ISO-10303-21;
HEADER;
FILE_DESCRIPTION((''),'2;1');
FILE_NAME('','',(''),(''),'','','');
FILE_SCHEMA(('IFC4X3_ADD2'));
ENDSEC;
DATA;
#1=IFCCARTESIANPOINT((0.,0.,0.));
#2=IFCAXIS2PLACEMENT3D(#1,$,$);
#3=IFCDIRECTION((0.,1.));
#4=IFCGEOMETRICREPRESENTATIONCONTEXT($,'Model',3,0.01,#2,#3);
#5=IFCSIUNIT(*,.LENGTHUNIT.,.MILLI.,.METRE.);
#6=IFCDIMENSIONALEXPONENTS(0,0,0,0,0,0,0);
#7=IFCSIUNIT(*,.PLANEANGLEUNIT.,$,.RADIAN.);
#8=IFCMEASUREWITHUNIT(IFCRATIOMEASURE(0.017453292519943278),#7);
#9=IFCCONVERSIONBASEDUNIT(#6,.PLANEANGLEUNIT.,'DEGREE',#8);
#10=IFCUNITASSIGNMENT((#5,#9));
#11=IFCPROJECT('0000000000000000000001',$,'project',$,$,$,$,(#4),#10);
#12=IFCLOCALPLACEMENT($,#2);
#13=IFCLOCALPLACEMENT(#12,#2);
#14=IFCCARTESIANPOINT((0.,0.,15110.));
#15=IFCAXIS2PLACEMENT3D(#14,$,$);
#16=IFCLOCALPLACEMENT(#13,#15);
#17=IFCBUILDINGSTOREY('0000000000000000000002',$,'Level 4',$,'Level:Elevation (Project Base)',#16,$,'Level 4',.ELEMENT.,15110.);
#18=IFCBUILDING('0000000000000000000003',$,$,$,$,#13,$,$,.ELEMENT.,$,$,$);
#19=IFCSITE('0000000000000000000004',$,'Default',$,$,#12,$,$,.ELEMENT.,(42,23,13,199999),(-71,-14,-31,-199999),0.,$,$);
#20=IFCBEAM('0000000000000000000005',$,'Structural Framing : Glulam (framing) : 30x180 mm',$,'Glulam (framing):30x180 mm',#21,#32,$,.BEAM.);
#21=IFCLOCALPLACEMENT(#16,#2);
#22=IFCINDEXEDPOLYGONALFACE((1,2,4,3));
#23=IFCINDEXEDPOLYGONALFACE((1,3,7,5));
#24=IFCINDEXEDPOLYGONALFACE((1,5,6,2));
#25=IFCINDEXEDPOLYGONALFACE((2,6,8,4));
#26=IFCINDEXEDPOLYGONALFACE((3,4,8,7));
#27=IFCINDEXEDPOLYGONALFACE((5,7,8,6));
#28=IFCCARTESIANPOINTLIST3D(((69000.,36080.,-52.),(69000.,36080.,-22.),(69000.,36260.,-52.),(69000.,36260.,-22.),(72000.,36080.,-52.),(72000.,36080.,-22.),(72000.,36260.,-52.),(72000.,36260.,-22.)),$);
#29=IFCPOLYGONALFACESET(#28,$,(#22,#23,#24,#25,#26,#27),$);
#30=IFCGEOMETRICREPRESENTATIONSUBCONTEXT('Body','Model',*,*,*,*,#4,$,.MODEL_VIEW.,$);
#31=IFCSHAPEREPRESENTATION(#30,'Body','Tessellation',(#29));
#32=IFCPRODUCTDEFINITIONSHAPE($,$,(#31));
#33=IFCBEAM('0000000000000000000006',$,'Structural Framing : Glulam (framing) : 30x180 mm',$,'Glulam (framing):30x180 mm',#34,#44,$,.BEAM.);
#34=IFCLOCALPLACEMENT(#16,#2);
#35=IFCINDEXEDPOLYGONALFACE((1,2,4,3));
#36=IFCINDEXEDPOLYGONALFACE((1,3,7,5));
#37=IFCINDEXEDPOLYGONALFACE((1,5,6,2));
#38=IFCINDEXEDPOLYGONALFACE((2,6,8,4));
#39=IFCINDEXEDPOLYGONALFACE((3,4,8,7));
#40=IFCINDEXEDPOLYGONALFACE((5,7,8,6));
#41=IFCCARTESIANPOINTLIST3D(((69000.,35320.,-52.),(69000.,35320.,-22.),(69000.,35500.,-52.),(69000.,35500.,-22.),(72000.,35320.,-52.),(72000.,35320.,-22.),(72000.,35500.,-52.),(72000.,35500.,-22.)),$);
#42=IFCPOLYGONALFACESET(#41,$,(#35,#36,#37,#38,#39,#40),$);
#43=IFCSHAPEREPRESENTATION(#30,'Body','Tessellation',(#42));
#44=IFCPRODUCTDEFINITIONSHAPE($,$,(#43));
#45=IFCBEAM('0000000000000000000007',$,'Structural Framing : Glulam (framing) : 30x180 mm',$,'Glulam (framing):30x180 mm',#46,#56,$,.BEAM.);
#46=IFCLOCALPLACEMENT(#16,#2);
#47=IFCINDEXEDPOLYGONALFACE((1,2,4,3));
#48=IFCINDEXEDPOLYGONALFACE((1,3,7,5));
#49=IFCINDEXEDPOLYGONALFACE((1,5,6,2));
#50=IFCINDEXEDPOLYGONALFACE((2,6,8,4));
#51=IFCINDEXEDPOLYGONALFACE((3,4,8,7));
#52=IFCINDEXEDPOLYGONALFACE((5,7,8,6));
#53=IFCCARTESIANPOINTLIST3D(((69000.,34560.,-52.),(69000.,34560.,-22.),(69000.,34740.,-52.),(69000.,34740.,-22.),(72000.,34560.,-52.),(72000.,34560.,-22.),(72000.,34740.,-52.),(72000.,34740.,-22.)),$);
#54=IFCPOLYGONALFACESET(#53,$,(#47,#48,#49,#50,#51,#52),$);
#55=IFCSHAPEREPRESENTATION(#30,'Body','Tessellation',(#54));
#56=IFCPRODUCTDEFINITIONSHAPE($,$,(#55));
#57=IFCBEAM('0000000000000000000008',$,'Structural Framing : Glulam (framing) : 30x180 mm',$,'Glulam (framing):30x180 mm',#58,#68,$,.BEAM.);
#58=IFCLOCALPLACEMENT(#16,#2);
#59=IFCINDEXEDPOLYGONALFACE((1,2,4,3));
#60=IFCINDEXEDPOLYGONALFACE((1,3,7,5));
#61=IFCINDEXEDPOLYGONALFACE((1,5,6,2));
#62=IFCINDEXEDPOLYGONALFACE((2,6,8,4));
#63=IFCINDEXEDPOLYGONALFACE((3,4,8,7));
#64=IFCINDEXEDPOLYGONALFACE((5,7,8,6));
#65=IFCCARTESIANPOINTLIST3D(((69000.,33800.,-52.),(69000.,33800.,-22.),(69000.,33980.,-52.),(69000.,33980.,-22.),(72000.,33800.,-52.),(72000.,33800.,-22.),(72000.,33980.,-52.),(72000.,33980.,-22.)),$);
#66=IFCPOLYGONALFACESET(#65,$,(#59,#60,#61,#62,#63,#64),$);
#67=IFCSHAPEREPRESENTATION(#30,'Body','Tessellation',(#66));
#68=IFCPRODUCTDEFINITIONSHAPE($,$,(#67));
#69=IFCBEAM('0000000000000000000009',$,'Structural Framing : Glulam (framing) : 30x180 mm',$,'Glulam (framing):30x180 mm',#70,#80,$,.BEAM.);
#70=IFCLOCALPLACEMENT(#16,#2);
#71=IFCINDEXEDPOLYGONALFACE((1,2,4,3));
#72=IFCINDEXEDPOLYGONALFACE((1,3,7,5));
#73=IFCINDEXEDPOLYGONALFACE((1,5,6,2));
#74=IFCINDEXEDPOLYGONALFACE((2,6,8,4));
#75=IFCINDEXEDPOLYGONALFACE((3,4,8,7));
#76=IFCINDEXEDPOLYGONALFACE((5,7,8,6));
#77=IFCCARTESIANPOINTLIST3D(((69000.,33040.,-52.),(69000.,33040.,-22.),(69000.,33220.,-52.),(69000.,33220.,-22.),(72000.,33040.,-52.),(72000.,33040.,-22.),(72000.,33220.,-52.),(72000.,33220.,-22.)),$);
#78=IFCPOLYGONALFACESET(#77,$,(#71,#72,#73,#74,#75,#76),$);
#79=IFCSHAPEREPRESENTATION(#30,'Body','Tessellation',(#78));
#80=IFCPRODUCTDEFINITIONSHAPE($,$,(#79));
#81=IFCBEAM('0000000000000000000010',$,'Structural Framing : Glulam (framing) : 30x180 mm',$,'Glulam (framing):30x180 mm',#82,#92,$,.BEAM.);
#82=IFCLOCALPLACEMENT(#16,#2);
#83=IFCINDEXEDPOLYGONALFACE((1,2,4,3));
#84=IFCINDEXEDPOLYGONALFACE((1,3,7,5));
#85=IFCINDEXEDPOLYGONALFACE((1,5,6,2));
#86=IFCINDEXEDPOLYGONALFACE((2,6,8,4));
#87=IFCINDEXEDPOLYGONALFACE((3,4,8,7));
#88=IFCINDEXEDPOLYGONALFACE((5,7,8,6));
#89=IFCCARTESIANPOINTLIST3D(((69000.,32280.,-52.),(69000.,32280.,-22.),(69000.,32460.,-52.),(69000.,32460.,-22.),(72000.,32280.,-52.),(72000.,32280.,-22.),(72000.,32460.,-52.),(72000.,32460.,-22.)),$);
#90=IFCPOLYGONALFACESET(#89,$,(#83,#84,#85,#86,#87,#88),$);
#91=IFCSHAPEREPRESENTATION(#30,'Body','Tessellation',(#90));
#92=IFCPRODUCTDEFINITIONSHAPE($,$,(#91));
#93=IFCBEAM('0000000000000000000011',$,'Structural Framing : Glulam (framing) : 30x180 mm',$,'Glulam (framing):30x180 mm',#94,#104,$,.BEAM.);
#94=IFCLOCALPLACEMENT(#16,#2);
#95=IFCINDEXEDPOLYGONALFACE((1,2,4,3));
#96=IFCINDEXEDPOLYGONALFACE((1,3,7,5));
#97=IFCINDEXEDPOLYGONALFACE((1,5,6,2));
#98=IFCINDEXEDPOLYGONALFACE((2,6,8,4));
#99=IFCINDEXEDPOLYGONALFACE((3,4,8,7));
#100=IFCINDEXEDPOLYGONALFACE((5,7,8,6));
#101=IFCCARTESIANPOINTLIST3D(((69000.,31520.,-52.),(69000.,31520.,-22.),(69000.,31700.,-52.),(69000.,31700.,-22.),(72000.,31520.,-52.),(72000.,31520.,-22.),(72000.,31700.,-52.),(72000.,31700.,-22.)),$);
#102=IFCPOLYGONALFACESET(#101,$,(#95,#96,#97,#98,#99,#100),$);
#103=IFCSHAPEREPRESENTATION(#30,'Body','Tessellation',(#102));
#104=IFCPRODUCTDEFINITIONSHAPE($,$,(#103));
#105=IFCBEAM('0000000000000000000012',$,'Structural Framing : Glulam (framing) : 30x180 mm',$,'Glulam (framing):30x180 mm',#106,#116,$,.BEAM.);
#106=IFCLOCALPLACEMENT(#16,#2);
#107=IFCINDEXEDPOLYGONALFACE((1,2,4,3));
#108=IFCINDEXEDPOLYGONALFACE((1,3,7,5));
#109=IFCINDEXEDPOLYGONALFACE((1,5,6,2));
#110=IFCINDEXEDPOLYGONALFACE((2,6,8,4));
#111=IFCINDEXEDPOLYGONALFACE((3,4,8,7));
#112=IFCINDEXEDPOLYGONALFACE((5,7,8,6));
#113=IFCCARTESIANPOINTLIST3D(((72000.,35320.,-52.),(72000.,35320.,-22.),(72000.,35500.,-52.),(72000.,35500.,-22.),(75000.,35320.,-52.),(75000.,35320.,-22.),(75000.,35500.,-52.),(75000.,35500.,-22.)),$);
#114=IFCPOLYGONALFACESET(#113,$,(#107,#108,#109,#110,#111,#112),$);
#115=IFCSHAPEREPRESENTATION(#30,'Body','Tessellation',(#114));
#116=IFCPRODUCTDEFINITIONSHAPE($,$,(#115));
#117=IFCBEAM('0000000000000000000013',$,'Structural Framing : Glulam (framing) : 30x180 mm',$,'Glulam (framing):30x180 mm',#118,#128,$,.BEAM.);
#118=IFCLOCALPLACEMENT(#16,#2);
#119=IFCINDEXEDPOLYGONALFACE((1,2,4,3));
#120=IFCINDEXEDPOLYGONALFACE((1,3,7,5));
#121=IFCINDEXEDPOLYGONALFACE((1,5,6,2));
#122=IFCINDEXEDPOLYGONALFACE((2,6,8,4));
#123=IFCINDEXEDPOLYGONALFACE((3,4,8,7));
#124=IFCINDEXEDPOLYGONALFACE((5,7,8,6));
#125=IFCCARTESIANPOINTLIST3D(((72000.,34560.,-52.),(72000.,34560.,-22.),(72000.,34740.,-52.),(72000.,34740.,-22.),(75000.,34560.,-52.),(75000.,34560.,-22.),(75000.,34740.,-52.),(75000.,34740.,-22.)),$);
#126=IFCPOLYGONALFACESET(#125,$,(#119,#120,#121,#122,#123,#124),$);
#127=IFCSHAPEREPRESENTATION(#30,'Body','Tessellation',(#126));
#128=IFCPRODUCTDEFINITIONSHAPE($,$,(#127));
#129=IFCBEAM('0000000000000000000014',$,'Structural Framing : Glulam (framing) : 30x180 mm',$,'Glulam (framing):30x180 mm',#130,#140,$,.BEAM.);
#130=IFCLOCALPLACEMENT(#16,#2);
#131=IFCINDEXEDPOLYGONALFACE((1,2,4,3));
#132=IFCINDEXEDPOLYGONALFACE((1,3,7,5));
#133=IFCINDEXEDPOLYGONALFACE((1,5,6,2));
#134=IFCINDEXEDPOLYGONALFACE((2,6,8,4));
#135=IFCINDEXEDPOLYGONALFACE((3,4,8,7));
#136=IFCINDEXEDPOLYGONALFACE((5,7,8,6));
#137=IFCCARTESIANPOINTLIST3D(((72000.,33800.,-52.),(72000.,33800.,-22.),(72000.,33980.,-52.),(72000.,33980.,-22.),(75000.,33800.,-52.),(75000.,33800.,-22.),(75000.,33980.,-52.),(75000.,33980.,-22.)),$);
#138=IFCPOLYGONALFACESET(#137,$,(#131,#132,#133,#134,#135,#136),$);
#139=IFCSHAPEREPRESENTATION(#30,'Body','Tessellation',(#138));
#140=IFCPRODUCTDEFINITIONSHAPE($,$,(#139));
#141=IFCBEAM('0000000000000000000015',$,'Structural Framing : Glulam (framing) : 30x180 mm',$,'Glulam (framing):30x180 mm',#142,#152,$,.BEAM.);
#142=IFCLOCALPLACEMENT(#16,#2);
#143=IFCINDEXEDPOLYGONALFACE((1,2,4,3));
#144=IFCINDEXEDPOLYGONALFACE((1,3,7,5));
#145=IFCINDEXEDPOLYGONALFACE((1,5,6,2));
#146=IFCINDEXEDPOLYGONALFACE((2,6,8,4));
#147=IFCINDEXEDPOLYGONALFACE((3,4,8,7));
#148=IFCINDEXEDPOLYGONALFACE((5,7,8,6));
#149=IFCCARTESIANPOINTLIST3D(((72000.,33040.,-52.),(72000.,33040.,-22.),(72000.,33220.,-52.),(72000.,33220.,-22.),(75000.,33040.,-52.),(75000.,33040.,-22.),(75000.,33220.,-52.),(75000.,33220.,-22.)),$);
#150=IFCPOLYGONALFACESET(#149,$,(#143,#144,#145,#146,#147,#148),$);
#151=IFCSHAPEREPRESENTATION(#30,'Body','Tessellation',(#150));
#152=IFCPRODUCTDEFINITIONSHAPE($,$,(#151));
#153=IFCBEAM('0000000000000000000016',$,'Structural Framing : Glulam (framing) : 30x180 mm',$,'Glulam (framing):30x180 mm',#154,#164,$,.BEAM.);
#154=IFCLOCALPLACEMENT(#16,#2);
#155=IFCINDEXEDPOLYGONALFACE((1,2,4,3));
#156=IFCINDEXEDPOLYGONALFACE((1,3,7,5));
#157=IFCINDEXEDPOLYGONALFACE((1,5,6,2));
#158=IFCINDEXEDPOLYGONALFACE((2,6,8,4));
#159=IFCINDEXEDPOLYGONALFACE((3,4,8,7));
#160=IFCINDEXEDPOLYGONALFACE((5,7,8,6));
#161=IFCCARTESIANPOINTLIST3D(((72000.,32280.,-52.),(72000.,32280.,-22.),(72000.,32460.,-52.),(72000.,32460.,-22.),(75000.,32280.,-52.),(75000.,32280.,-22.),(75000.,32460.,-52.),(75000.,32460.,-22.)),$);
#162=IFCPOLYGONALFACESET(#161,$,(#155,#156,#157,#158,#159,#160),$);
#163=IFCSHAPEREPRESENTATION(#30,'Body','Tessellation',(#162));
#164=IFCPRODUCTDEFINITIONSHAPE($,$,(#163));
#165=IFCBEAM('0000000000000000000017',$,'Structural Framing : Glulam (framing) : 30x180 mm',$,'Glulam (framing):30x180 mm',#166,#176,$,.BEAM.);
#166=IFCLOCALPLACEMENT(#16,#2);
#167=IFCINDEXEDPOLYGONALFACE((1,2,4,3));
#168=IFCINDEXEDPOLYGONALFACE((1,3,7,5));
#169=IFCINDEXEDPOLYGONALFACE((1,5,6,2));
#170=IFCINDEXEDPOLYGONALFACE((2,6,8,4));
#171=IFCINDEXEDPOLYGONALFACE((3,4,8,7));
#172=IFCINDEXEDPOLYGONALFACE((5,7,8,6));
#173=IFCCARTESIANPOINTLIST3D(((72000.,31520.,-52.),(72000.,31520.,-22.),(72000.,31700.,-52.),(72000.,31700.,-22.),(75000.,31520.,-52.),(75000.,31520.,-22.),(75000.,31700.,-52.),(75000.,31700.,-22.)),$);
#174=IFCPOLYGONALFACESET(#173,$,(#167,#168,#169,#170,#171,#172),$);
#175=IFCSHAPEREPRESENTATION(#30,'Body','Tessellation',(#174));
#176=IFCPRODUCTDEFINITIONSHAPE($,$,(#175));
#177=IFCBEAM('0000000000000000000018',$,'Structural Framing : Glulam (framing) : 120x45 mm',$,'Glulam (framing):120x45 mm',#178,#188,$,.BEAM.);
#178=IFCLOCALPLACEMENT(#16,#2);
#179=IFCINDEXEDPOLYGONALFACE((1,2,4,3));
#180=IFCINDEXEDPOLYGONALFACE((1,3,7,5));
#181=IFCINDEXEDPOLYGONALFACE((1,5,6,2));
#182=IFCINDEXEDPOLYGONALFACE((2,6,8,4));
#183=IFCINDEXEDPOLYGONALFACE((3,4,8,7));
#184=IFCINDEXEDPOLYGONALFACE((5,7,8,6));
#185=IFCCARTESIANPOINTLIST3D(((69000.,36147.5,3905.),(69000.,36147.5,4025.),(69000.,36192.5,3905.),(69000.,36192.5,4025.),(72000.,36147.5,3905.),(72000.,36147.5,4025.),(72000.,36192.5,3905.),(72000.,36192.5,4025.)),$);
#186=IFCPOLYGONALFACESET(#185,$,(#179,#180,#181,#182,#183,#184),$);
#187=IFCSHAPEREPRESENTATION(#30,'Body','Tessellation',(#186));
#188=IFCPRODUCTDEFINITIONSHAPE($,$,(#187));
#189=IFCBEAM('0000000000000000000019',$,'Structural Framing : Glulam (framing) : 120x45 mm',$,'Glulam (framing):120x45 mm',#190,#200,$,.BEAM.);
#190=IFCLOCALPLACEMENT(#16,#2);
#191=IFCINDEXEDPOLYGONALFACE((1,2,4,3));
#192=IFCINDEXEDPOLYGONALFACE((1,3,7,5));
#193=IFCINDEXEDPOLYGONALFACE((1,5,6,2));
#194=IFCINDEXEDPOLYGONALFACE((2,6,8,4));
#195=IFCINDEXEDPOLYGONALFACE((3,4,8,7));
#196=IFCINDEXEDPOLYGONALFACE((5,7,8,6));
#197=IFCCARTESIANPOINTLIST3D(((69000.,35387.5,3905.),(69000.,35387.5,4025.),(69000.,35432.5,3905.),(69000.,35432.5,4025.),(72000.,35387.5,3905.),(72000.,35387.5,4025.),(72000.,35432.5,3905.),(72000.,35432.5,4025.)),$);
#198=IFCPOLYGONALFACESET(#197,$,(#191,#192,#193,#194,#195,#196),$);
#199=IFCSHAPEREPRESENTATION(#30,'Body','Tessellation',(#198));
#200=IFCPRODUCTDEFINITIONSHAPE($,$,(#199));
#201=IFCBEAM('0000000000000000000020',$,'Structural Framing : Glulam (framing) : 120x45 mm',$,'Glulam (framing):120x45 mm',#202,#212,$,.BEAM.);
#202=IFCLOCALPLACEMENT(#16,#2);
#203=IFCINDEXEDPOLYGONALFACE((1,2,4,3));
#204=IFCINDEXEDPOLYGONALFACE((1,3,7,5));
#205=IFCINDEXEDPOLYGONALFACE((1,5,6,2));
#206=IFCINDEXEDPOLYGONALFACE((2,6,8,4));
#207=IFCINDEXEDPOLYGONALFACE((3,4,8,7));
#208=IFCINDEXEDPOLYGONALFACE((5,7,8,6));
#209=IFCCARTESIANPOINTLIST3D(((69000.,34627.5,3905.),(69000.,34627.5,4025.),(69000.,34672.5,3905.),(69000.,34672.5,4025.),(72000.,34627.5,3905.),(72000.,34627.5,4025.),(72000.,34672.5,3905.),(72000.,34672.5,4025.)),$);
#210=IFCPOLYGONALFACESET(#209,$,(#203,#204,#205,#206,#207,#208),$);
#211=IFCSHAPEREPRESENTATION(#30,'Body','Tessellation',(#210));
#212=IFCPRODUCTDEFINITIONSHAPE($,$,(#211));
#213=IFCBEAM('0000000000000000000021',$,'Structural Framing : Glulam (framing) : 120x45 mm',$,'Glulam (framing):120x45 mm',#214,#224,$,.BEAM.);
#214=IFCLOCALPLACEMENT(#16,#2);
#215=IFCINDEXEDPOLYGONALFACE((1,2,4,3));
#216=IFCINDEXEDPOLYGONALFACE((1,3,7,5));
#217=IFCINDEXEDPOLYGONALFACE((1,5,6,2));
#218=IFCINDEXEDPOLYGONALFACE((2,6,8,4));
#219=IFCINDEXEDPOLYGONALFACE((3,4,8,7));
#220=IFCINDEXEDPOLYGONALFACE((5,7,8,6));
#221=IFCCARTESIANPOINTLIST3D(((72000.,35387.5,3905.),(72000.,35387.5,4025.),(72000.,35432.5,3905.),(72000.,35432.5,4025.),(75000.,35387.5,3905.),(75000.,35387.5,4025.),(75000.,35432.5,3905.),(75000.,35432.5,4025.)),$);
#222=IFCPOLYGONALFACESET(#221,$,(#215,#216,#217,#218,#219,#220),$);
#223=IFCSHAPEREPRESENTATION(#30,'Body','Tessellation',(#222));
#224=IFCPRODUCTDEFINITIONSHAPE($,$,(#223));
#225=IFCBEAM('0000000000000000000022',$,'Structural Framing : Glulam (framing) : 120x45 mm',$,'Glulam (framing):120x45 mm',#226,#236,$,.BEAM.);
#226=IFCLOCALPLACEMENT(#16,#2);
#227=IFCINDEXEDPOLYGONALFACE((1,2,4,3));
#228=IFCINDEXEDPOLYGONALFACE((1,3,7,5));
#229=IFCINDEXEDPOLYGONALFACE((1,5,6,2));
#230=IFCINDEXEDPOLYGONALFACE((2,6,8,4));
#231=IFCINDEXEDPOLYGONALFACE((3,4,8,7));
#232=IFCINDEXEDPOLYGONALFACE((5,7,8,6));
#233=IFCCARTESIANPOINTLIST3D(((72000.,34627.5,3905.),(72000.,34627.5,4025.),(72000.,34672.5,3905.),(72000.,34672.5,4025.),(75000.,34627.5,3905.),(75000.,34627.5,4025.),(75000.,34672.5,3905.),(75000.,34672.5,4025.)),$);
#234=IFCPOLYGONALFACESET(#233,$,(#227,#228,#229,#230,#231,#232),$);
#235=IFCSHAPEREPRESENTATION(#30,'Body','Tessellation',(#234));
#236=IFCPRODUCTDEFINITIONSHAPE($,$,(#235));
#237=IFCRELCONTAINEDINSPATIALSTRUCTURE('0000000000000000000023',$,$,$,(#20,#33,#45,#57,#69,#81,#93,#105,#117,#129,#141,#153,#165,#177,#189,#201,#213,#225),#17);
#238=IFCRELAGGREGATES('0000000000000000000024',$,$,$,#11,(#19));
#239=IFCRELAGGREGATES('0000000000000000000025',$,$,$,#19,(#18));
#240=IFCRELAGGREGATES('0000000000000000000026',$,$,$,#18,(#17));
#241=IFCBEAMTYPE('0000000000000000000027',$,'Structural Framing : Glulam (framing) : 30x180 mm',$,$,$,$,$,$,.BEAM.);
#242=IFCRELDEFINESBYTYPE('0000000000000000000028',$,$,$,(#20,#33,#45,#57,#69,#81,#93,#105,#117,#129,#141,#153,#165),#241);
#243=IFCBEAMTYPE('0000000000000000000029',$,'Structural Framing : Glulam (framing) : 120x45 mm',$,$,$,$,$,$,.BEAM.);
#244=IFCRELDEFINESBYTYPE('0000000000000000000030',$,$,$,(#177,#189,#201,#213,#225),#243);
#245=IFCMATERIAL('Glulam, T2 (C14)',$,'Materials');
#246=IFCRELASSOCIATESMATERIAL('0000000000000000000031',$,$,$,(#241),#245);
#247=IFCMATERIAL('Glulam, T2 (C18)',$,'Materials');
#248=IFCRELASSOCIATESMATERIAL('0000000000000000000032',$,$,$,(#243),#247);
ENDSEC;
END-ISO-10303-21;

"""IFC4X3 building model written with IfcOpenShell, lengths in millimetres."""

from ifc_helpers import new_model, entity, si_unit, converted_unit, direction, frame, origin, origin_2d_with_axis, place, context, subcontext, project, spatial, rectangle, extrude, source, transform, mapped, material, material_profile, profile_set, type_object, type_shapes, element, save


model = new_model("IFC4X3")

# Units and contexts
model_context = context("Model", 3, precision=0.01, world=origin(), true_north=direction((0.0, 1.0)))
body_context = subcontext(model_context, "Body", "Model", "MODEL_VIEW")
ifc_project = project(units=[si_unit("LENGTHUNIT", "METRE", prefix="MILLI"), converted_unit("PLANEANGLEUNIT", "DEGREE", entity("IfcRatioMeasure", 0.017453292519943278), si_unit("PLANEANGLEUNIT", "RADIAN"), dimensions=[0, 0, 0, 0, 0, 0, 0])], contexts=[model_context])

# Site, building, storey
site_placement = place(None, origin())
site = spatial("IfcSite", under=ifc_project, at=site_placement, Name="Default", CompositionType="ELEMENT", RefLatitude=(42, 23, 13, 199999), RefLongitude=(-71, -14, -31, -199999), RefElevation=0.0)
building_placement = place(site_placement, origin())
building = spatial("IfcBuilding", under=site, at=building_placement, CompositionType="ELEMENT")
storey_placement = place(building_placement, frame((0.0, 0.0, 15110.0)))
storey = spatial("IfcBuildingStorey", under=building, at=storey_placement, Name="Level 4", ObjectType="Level:Elevation (Project Base)", LongName="Level 4", CompositionType="ELEMENT", Elevation=15110.0)

# Beams
ifc_material_1 = material(Name="Glulam, T2 (C14)", Category="Materials")
ifc_material_profile_1 = material_profile(ifc_material_1, rectangle(XDim=30.0, YDim=180.0, at=origin_2d_with_axis()), Name="30x180 mm")
ifc_profile_set_1 = profile_set([ifc_material_profile_1], Name="30x180 mm")
beam_type_1 = type_object("IfcBeamType", Name="Structural Framing : Glulam (framing) : 30x180 mm", PredefinedType="BEAM", material=ifc_profile_set_1)
shared_shape_1 = source(origin(), body_context, "Body", "SweptSolid", [
    extrude(rectangle(XDim=30.0, YDim=180.0, at=origin_2d_with_axis()), frame((500.0, 0.0, 0.0), z_axis=(1.0, 0.0, 0.0), x_axis=(0.0, 0.0, -1.0)), (0.0, 0.0, 1.0), 3000.0),
])
type_shapes(beam_type_1, [shared_shape_1])
for number, where, name in (
    (1, (68500.0, 36170.0, -37.0), "Structural Framing : Glulam (framing) : 30x180 mm"),
    (2, (68500.0, 35410.0, -37.0), "Structural Framing : Glulam (framing) : 30x180 mm"),
    (3, (68500.0, 34650.0, -37.0), "Structural Framing : Glulam (framing) : 30x180 mm"),
    (4, (68500.0, 33890.0, -37.0), "Structural Framing : Glulam (framing) : 30x180 mm"),
    (5, (68500.0, 33130.0, -37.0), "Structural Framing : Glulam (framing) : 30x180 mm"),
    (6, (68500.0, 32370.0, -37.0), "Structural Framing : Glulam (framing) : 30x180 mm"),
    (7, (68500.0, 31610.0, -37.0), "Structural Framing : Glulam (framing) : 30x180 mm"),
    (8, (71500.0, 35410.0, -37.0), "Structural Framing : Glulam (framing) : 30x180 mm"),
    (9, (71500.0, 34650.0, -37.0), "Structural Framing : Glulam (framing) : 30x180 mm"),
    (10, (71500.0, 33890.0, -37.0), "Structural Framing : Glulam (framing) : 30x180 mm"),
    (11, (71500.0, 33130.0, -37.0), "Structural Framing : Glulam (framing) : 30x180 mm"),
    (12, (71500.0, 32370.0, -37.0), "Structural Framing : Glulam (framing) : 30x180 mm"),
    (13, (71500.0, 31610.0, -37.0), "Structural Framing : Glulam (framing) : 30x180 mm"),
):
    element("IfcBeam", number, at=place(storey_placement, frame(where)), inside=storey, type_object=beam_type_1, Name=name, ObjectType="Glulam (framing):30x180 mm", PredefinedType="BEAM", context=body_context, shape_type="MappedRepresentation", body=[
        mapped(shared_shape_1, transform((0.0, 0.0, 0.0), scale=1.0)),
    ])
ifc_material_2 = material(Name="Glulam, T2 (C18)", Category="Materials")
ifc_material_profile_2 = material_profile(ifc_material_2, rectangle(XDim=120.0, YDim=45.0, at=origin_2d_with_axis()), Name="120x45 mm")
ifc_profile_set_2 = profile_set([ifc_material_profile_2], Name="120x45 mm")
beam_type_2 = type_object("IfcBeamType", Name="Structural Framing : Glulam (framing) : 120x45 mm", PredefinedType="BEAM", material=ifc_profile_set_2)
shared_shape_2 = source(origin(), body_context, "Body", "SweptSolid", [
    extrude(rectangle(XDim=120.0, YDim=45.0, at=origin_2d_with_axis()), frame((500.0, 0.0, 0.0), z_axis=(1.0, 0.0, 0.0), x_axis=(0.0, 0.0, -1.0)), (0.0, 0.0, 1.0), 3000.0),
])
type_shapes(beam_type_2, [shared_shape_2])
for number, where, name in (
    (14, (68500.0, 36170.0, 3965.0), "Structural Framing : Glulam (framing) : 120x45 mm"),
    (15, (68500.0, 35410.0, 3965.0), "Structural Framing : Glulam (framing) : 120x45 mm"),
    (16, (68500.0, 34650.0, 3965.0), "Structural Framing : Glulam (framing) : 120x45 mm"),
    (17, (71500.0, 35410.0, 3965.0), "Structural Framing : Glulam (framing) : 120x45 mm"),
    (18, (71500.0, 34650.0, 3965.0), "Structural Framing : Glulam (framing) : 120x45 mm"),
):
    element("IfcBeam", number, at=place(storey_placement, frame(where)), inside=storey, type_object=beam_type_2, Name=name, ObjectType="Glulam (framing):120x45 mm", PredefinedType="BEAM", context=body_context, shape_type="MappedRepresentation", body=[
        mapped(shared_shape_2, transform((0.0, 0.0, 0.0), scale=1.0)),
    ])

save(model, "model.ifc")
